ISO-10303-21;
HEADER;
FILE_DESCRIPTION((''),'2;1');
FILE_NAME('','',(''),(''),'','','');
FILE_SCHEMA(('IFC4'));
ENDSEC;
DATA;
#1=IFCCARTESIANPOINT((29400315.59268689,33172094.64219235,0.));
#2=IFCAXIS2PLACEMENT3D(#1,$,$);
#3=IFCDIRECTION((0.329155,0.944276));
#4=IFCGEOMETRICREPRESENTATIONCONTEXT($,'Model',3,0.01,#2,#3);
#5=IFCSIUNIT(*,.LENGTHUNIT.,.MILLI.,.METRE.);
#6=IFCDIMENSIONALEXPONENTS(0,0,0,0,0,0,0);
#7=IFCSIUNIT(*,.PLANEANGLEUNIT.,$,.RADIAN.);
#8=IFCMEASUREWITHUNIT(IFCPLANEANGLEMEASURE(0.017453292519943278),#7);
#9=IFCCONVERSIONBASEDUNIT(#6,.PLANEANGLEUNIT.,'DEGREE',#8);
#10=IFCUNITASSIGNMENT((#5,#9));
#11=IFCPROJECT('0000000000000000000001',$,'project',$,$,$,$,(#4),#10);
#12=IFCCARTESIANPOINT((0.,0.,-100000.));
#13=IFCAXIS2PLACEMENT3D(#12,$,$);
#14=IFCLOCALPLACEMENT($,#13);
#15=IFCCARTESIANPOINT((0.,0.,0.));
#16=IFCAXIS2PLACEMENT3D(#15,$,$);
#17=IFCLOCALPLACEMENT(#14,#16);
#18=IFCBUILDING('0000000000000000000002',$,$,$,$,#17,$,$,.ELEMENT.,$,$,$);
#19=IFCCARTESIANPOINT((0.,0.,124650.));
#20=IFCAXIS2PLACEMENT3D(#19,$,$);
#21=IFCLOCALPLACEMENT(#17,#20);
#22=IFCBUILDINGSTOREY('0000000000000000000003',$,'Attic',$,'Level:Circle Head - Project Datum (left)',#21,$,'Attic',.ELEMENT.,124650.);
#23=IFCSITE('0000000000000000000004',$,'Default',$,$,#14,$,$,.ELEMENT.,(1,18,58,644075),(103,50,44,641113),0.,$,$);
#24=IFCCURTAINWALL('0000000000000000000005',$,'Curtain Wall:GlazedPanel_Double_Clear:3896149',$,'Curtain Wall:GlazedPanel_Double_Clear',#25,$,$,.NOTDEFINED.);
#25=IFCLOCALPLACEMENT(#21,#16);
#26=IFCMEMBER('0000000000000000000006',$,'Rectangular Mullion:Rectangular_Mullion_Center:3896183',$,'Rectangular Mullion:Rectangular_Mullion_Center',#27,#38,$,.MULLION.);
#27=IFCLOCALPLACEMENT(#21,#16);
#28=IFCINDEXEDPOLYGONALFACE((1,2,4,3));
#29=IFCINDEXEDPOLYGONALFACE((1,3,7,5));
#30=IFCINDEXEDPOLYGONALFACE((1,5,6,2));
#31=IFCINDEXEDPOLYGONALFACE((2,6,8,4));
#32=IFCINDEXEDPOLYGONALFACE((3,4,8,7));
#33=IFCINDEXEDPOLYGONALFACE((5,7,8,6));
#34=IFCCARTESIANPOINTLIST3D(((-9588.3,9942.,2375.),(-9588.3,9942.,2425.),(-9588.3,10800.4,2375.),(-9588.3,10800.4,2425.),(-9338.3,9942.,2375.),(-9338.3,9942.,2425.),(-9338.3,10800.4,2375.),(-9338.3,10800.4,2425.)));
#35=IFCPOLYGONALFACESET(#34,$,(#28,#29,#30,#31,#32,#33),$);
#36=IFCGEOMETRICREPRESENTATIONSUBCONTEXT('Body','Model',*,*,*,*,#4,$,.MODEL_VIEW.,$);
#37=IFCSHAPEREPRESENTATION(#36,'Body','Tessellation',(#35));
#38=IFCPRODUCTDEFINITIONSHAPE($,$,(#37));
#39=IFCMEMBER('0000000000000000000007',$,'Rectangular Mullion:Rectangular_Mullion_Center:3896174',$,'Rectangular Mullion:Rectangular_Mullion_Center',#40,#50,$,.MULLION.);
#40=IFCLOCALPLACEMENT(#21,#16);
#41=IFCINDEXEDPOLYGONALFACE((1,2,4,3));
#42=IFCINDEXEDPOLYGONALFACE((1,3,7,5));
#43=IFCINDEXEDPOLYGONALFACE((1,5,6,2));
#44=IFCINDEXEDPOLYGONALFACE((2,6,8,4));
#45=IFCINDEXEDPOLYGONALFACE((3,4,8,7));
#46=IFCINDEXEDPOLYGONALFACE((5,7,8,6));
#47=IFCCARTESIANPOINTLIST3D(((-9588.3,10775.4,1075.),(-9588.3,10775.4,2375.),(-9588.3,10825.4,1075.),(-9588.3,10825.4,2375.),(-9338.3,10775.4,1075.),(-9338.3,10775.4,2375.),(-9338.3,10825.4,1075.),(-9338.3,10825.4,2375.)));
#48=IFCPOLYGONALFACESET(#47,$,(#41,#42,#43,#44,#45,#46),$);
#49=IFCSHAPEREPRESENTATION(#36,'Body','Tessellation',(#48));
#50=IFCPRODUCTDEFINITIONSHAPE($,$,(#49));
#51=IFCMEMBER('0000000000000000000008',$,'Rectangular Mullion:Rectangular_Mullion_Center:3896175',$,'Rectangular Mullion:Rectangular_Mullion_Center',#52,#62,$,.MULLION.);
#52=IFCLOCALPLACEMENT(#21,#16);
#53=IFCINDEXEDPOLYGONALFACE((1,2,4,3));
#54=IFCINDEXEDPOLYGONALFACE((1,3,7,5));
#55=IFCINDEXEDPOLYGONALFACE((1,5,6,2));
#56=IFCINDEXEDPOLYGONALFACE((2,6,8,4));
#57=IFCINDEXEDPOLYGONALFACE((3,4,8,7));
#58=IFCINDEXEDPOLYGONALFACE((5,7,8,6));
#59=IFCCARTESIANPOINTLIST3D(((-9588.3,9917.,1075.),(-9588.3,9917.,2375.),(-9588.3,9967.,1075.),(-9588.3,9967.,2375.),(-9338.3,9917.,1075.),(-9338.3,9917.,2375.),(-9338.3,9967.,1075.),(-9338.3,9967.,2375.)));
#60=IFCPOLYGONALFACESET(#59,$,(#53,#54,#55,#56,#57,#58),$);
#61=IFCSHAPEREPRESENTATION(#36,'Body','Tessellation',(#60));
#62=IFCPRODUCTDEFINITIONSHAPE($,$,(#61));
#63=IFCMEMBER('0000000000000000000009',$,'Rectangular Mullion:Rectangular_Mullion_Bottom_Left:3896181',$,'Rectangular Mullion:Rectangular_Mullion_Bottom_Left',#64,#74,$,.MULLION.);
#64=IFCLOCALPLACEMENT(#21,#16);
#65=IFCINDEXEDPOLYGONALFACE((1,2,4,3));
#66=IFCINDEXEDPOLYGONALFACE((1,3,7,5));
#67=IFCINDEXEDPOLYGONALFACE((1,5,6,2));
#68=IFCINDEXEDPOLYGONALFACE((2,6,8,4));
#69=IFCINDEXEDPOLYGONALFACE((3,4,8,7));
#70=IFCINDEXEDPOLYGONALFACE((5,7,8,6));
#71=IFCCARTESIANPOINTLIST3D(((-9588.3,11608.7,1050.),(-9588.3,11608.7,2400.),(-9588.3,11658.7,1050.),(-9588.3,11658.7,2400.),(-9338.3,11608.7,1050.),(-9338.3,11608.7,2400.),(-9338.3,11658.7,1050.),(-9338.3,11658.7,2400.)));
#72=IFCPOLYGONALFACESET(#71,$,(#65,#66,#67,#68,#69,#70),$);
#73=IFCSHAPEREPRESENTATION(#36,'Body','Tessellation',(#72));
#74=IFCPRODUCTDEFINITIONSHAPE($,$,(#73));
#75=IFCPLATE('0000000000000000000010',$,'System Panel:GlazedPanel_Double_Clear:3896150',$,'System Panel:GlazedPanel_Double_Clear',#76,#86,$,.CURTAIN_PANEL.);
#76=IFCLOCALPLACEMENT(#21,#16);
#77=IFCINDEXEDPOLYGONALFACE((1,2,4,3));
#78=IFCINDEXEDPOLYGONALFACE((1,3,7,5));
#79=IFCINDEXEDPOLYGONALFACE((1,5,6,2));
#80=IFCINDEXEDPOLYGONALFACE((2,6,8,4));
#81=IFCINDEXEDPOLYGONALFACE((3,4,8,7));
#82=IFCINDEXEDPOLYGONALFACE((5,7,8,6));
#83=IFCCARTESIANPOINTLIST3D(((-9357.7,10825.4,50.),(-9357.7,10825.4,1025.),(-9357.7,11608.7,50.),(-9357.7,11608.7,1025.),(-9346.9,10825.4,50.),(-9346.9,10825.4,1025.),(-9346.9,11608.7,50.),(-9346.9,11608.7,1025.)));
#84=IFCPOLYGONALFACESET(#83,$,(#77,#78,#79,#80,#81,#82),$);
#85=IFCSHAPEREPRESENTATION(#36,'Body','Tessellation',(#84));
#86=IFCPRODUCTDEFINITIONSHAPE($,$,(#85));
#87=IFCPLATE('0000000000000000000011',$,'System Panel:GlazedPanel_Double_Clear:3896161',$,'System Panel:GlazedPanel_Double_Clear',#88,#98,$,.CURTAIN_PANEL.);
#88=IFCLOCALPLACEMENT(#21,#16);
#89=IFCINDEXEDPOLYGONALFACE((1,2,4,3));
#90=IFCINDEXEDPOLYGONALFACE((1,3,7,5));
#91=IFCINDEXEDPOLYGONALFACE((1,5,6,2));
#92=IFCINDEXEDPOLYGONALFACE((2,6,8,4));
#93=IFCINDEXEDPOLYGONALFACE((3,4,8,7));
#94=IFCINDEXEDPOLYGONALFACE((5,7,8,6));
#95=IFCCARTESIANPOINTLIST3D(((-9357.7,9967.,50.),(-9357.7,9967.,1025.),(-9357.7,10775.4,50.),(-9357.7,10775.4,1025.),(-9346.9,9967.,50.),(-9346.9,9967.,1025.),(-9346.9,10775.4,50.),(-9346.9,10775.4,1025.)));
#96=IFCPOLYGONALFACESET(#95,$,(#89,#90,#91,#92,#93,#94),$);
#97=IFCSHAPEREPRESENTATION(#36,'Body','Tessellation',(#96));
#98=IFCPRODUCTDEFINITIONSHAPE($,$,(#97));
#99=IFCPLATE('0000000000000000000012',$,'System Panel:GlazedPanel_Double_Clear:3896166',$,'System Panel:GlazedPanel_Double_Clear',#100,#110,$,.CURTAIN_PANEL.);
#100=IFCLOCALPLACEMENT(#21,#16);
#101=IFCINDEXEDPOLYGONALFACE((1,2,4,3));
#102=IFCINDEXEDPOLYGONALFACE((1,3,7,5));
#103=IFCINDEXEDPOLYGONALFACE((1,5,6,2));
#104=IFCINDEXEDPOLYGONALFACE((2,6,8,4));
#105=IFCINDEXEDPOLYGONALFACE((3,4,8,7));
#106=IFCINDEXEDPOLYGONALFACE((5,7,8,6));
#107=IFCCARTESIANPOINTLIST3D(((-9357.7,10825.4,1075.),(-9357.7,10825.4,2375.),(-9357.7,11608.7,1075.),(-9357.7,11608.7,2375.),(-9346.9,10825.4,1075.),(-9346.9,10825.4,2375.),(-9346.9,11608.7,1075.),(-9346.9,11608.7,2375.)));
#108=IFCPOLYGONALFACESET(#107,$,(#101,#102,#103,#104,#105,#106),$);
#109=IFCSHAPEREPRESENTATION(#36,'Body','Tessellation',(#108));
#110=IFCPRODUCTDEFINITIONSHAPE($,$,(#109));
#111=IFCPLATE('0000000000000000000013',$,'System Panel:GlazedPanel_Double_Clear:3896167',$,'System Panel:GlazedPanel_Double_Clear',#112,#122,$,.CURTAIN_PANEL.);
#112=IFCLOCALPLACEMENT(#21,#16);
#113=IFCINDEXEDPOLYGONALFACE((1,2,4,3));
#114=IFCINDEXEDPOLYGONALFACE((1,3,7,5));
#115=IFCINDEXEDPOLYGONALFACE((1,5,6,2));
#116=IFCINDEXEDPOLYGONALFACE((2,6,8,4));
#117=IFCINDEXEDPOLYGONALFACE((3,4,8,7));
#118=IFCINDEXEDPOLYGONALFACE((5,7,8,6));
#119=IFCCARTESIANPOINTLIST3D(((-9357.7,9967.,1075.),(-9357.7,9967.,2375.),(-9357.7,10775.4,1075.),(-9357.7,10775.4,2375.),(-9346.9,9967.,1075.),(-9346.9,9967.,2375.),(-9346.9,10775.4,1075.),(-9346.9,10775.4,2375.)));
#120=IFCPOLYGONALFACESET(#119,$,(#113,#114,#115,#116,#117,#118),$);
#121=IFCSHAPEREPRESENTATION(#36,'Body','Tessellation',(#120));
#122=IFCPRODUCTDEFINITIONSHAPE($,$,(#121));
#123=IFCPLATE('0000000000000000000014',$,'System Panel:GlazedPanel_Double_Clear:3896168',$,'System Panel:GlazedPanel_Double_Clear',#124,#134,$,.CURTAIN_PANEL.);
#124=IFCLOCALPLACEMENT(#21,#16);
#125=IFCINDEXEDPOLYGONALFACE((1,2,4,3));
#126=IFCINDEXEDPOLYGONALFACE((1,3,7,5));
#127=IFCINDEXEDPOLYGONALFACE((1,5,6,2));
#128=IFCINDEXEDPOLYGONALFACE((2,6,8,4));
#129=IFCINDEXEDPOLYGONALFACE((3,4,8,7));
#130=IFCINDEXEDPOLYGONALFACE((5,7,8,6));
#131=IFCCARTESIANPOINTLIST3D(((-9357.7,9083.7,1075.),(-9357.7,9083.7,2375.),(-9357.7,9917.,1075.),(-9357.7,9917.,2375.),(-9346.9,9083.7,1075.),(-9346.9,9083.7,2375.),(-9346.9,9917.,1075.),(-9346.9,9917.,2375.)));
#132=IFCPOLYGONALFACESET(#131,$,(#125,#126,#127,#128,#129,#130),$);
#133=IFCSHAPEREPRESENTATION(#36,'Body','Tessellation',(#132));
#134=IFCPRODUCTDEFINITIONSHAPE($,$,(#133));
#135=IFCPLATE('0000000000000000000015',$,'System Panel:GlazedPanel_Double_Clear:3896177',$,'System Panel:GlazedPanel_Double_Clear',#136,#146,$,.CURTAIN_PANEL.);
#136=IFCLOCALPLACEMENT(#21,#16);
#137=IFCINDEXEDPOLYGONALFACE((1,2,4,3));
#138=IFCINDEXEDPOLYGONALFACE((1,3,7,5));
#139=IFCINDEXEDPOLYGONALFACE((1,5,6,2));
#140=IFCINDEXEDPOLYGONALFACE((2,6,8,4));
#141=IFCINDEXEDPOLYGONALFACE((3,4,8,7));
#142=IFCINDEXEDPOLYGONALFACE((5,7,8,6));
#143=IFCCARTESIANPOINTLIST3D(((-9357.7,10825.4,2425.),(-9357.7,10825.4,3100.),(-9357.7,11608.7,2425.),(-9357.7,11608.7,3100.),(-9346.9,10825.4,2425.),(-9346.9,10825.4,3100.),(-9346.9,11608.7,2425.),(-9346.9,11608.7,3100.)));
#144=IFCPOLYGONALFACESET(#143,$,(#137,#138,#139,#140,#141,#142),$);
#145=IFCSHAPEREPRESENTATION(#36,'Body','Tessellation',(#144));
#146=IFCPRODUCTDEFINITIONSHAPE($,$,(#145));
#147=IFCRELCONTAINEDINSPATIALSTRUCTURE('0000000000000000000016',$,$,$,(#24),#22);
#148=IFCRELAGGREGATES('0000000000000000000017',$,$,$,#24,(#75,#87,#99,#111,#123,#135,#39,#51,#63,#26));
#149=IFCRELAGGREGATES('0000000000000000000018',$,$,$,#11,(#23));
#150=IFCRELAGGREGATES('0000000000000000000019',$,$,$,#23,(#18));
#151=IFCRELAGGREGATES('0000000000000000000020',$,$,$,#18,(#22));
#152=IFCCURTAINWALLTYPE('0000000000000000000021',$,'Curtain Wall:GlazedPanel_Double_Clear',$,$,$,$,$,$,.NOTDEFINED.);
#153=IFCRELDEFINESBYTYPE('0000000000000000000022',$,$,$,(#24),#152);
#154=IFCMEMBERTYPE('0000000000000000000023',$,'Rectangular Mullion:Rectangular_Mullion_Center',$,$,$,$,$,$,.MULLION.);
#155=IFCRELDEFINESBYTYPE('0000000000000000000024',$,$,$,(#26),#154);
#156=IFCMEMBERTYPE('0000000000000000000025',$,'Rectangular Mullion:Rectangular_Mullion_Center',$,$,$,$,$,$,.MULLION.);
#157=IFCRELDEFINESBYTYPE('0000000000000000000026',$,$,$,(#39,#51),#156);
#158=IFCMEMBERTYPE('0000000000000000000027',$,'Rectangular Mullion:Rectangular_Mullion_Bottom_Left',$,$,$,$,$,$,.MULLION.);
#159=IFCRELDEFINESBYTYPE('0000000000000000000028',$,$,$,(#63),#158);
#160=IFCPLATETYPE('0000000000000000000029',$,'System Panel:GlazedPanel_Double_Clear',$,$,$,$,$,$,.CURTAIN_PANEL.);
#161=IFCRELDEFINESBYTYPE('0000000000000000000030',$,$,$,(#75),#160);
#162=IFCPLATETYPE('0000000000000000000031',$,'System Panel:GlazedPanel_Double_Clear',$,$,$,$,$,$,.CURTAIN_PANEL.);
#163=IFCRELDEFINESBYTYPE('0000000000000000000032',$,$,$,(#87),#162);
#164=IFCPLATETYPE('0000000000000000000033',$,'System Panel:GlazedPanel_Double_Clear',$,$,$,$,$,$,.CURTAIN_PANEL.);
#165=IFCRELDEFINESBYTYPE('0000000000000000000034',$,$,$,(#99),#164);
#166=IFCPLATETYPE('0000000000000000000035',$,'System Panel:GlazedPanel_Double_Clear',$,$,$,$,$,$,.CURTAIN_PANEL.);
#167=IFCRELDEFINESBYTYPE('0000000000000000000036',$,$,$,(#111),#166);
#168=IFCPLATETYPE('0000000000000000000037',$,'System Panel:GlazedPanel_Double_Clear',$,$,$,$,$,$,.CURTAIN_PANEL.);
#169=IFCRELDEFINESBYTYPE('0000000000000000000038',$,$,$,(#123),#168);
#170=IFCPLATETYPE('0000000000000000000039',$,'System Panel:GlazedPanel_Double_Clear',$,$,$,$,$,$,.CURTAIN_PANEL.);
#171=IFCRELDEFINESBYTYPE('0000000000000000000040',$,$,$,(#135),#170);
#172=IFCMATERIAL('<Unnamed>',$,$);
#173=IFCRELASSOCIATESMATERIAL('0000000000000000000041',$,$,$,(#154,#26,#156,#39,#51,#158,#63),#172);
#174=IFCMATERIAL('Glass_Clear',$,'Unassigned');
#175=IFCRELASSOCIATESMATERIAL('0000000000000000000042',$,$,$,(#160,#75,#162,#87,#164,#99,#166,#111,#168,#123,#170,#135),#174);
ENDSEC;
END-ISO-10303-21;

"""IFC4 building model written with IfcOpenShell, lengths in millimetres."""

from ifc_helpers import new_model, entity, si_unit, converted_unit, direction, frame, origin, place, context, subcontext, project, spatial, indexed_curve, outline, extrude, source, transform, mapped, material, type_object, type_shapes, element, aggregate, save


model = new_model("IFC4")

# Units and contexts
model_context = context("Model", 3, precision=0.01, world=frame((29400315.59268689, 33172094.64219235, 0.0)), true_north=direction((0.329155, 0.944276)))
body_context = subcontext(model_context, "Body", "Model", "MODEL_VIEW")
ifc_project = project(units=[si_unit("LENGTHUNIT", "METRE", prefix="MILLI"), converted_unit("PLANEANGLEUNIT", "DEGREE", entity("IfcPlaneAngleMeasure", 0.017453292519943278), si_unit("PLANEANGLEUNIT", "RADIAN"), dimensions=[0, 0, 0, 0, 0, 0, 0])], contexts=[model_context])

# Site, building, storey
site_placement = place(None, frame((0.0, 0.0, -100000.0)))
site = spatial("IfcSite", under=ifc_project, at=site_placement, Name="Default", CompositionType="ELEMENT", RefLatitude=(1, 18, 58, 644075), RefLongitude=(103, 50, 44, 641113), RefElevation=0.0)
building_placement = place(site_placement, origin())
building = spatial("IfcBuilding", under=site, at=building_placement, CompositionType="ELEMENT")
storey_placement = place(building_placement, frame((0.0, 0.0, 124650.0)))
storey = spatial("IfcBuildingStorey", under=building, at=storey_placement, Name="Attic", ObjectType="Level:Circle Head - Project Datum (left)", LongName="Attic", CompositionType="ELEMENT", Elevation=124650.0)

# Curtain wall, members, plates
curtain_wall_type = type_object("IfcCurtainWallType", Name="Curtain Wall:GlazedPanel_Double_Clear", PredefinedType="NOTDEFINED")
curtain_wall_placement = place(storey_placement, frame((0.0, 0.0, -124650.0)))
curtain_wall = element("IfcCurtainWall", 1, at=curtain_wall_placement, inside=storey, type_object=curtain_wall_type, Name="Curtain Wall:GlazedPanel_Double_Clear:3896149", ObjectType="Curtain Wall:GlazedPanel_Double_Clear", PredefinedType="NOTDEFINED")
ifc_material_1 = material(Name="<Unnamed>")
member_type_1 = type_object("IfcMemberType", Name="Rectangular Mullion:Rectangular_Mullion_Center", PredefinedType="MULLION", material=ifc_material_1)
shared_shape_1 = source(origin(), body_context, "Body", "SweptSolid", [
    extrude(outline(indexed_curve([(-25.0, -125.0), (25.0, -125.0), (25.0, 125.0), (-25.0, 125.0), (-25.0, -125.0)], self_intersect=False)), frame((0.0, 0.0, -858.3), z_axis=(0.0, 0.0, 1.0), x_axis=(-1.0, 0.0, 0.0)), (0.0, 0.0, 1.0), 858.3),
])
type_shapes(member_type_1, [shared_shape_1])
member_1_placement = place(curtain_wall_placement, frame((-9463.3, 9942.0, 127050.0), z_axis=(0.0, -1.0, 0.0), x_axis=(0.0, 0.0, 1.0)))
member_1 = element("IfcMember", 2, at=member_1_placement, type_object=member_type_1, material=ifc_material_1, Name="Rectangular Mullion:Rectangular_Mullion_Center:3896183", ObjectType="Rectangular Mullion:Rectangular_Mullion_Center", PredefinedType="MULLION", context=body_context, shape_type="MappedRepresentation", body=[
    mapped(shared_shape_1, transform((0.0, 0.0, 0.0), scale=1.0)),
])
member_type_2 = type_object("IfcMemberType", Name="Rectangular Mullion:Rectangular_Mullion_Center", PredefinedType="MULLION", material=ifc_material_1)
shared_shape_2 = source(origin(), body_context, "Body", "SweptSolid", [
    extrude(outline(indexed_curve([(-25.0, -125.0), (25.0, -125.0), (25.0, 125.0), (-25.0, 125.0), (-25.0, -125.0)], self_intersect=False)), frame((0.0, 0.0, -1300.0), z_axis=(0.0, 0.0, 1.0), x_axis=(-1.0, 0.0, 0.0)), (0.0, 0.0, 1.0), 1300.0),
])
type_shapes(member_type_2, [shared_shape_2])
member_2_placement = place(curtain_wall_placement, frame((-9463.3, 10800.4, 125725.0), z_axis=(0.0, 0.0, -1.0), x_axis=(0.0, -1.0, 0.0)))
member_2 = element("IfcMember", 3, at=member_2_placement, type_object=member_type_2, material=ifc_material_1, Name="Rectangular Mullion:Rectangular_Mullion_Center:3896174", ObjectType="Rectangular Mullion:Rectangular_Mullion_Center", PredefinedType="MULLION", context=body_context, shape_type="MappedRepresentation", body=[
    mapped(shared_shape_2, transform((0.0, 0.0, 0.0), scale=1.0)),
])
member_3_placement = place(curtain_wall_placement, frame((-9463.3, 9942.0, 125725.0), z_axis=(0.0, 0.0, -1.0), x_axis=(0.0, -1.0, 0.0)))
member_3 = element("IfcMember", 4, at=member_3_placement, type_object=member_type_2, material=ifc_material_1, Name="Rectangular Mullion:Rectangular_Mullion_Center:3896175", ObjectType="Rectangular Mullion:Rectangular_Mullion_Center", PredefinedType="MULLION", context=body_context, shape_type="MappedRepresentation", body=[
    mapped(shared_shape_2, transform((0.0, 0.0, 0.0), scale=1.0)),
])
member_type_3 = type_object("IfcMemberType", Name="Rectangular Mullion:Rectangular_Mullion_Bottom_Left", PredefinedType="MULLION", material=ifc_material_1)
shared_shape_3 = source(origin(), body_context, "Body", "SweptSolid", [
    extrude(outline(indexed_curve([(-25.0, -125.0), (25.0, -125.0), (25.0, 125.0), (-25.0, 125.0), (-25.0, -125.0)], self_intersect=False)), frame((-25.0, 0.0, -1350.0), z_axis=(0.0, 0.0, 1.0), x_axis=(-1.0, 0.0, 0.0)), (0.0, 0.0, 1.0), 1350.0),
])
type_shapes(member_type_3, [shared_shape_3])
member_4_placement = place(curtain_wall_placement, frame((-9463.3, 11658.7, 127050.0), z_axis=(0.0, 0.0, 1.0), x_axis=(0.0, 1.0, 0.0)))
member_4 = element("IfcMember", 5, at=member_4_placement, type_object=member_type_3, material=ifc_material_1, Name="Rectangular Mullion:Rectangular_Mullion_Bottom_Left:3896181", ObjectType="Rectangular Mullion:Rectangular_Mullion_Bottom_Left", PredefinedType="MULLION", context=body_context, shape_type="MappedRepresentation", body=[
    mapped(shared_shape_3, transform((0.0, 0.0, 0.0), scale=1.0)),
])
ifc_material_2 = material(Name="Glass_Clear", Category="Unassigned")
plate_type_1 = type_object("IfcPlateType", Name="System Panel:GlazedPanel_Double_Clear", PredefinedType="CURTAIN_PANEL", material=ifc_material_2)
shared_shape_4 = source(origin(), body_context, "Body", "SweptSolid", [
    extrude(outline(indexed_curve([(-5.4, -391.7), (5.4, -391.7), (5.4, 391.7), (-5.4, 391.7), (-5.4, -391.7)], self_intersect=False)), frame((0.0, 111.0, 0.0), z_axis=(0.0, 0.0, 1.0), x_axis=(0.0, 1.0, 0.0)), (0.0, 0.0, 1.0), 975.0),
])
type_shapes(plate_type_1, [shared_shape_4])
plate_1_placement = place(curtain_wall_placement, frame((-9463.3, 11217.0, 124700.0), z_axis=(0.0, 0.0, 1.0), x_axis=(0.0, -1.0, 0.0)))
plate_1 = element("IfcPlate", 6, at=plate_1_placement, type_object=plate_type_1, material=ifc_material_2, Name="System Panel:GlazedPanel_Double_Clear:3896150", ObjectType="System Panel:GlazedPanel_Double_Clear", PredefinedType="CURTAIN_PANEL", context=body_context, shape_type="MappedRepresentation", body=[
    mapped(shared_shape_4, transform((0.0, 0.0, 0.0), scale=1.0)),
])
plate_type_2 = type_object("IfcPlateType", Name="System Panel:GlazedPanel_Double_Clear", PredefinedType="CURTAIN_PANEL", material=ifc_material_2)
shared_shape_5 = source(origin(), body_context, "Body", "SweptSolid", [
    extrude(outline(indexed_curve([(-5.4, -404.2), (5.4, -404.2), (5.4, 404.2), (-5.4, 404.2), (-5.4, -404.2)], self_intersect=False)), frame((0.0, 111.0, 0.0), z_axis=(0.0, 0.0, 1.0), x_axis=(0.0, 1.0, 0.0)), (0.0, 0.0, 1.0), 975.0),
])
type_shapes(plate_type_2, [shared_shape_5])
plate_2_placement = place(curtain_wall_placement, frame((-9463.3, 10371.2, 124700.0), z_axis=(0.0, 0.0, 1.0), x_axis=(0.0, -1.0, 0.0)))
plate_2 = element("IfcPlate", 7, at=plate_2_placement, type_object=plate_type_2, material=ifc_material_2, Name="System Panel:GlazedPanel_Double_Clear:3896161", ObjectType="System Panel:GlazedPanel_Double_Clear", PredefinedType="CURTAIN_PANEL", context=body_context, shape_type="MappedRepresentation", body=[
    mapped(shared_shape_5, transform((0.0, 0.0, 0.0), scale=1.0)),
])
plate_type_3 = type_object("IfcPlateType", Name="System Panel:GlazedPanel_Double_Clear", PredefinedType="CURTAIN_PANEL", material=ifc_material_2)
shared_shape_6 = source(origin(), body_context, "Body", "SweptSolid", [
    extrude(outline(indexed_curve([(-5.4, -391.7), (5.4, -391.7), (5.4, 391.7), (-5.4, 391.7), (-5.4, -391.7)], self_intersect=False)), frame((0.0, 111.0, 0.0), z_axis=(0.0, 0.0, 1.0), x_axis=(0.0, 1.0, 0.0)), (0.0, 0.0, 1.0), 1300.0),
])
type_shapes(plate_type_3, [shared_shape_6])
plate_3_placement = place(curtain_wall_placement, frame((-9463.3, 11217.0, 125725.0), z_axis=(0.0, 0.0, 1.0), x_axis=(0.0, -1.0, 0.0)))
plate_3 = element("IfcPlate", 8, at=plate_3_placement, type_object=plate_type_3, material=ifc_material_2, Name="System Panel:GlazedPanel_Double_Clear:3896166", ObjectType="System Panel:GlazedPanel_Double_Clear", PredefinedType="CURTAIN_PANEL", context=body_context, shape_type="MappedRepresentation", body=[
    mapped(shared_shape_6, transform((0.0, 0.0, 0.0), scale=1.0)),
])
plate_type_4 = type_object("IfcPlateType", Name="System Panel:GlazedPanel_Double_Clear", PredefinedType="CURTAIN_PANEL", material=ifc_material_2)
shared_shape_7 = source(origin(), body_context, "Body", "SweptSolid", [
    extrude(outline(indexed_curve([(-5.4, -404.2), (5.4, -404.2), (5.4, 404.2), (-5.4, 404.2), (-5.4, -404.2)], self_intersect=False)), frame((0.0, 111.0, 0.0), z_axis=(0.0, 0.0, 1.0), x_axis=(0.0, 1.0, 0.0)), (0.0, 0.0, 1.0), 1300.0),
])
type_shapes(plate_type_4, [shared_shape_7])
plate_4_placement = place(curtain_wall_placement, frame((-9463.3, 10371.2, 125725.0), z_axis=(0.0, 0.0, 1.0), x_axis=(0.0, -1.0, 0.0)))
plate_4 = element("IfcPlate", 9, at=plate_4_placement, type_object=plate_type_4, material=ifc_material_2, Name="System Panel:GlazedPanel_Double_Clear:3896167", ObjectType="System Panel:GlazedPanel_Double_Clear", PredefinedType="CURTAIN_PANEL", context=body_context, shape_type="MappedRepresentation", body=[
    mapped(shared_shape_7, transform((0.0, 0.0, 0.0), scale=1.0)),
])
plate_type_5 = type_object("IfcPlateType", Name="System Panel:GlazedPanel_Double_Clear", PredefinedType="CURTAIN_PANEL", material=ifc_material_2)
shared_shape_8 = source(origin(), body_context, "Body", "SweptSolid", [
    extrude(outline(indexed_curve([(-5.4, -416.7), (5.4, -416.7), (5.4, 416.7), (-5.4, 416.7), (-5.4, -416.7)], self_intersect=False)), frame((0.0, 111.0, 0.0), z_axis=(0.0, 0.0, 1.0), x_axis=(0.0, 1.0, 0.0)), (0.0, 0.0, 1.0), 1300.0),
])
type_shapes(plate_type_5, [shared_shape_8])
plate_5_placement = place(curtain_wall_placement, frame((-9463.3, 9500.4, 125725.0), z_axis=(0.0, 0.0, 1.0), x_axis=(0.0, -1.0, 0.0)))
plate_5 = element("IfcPlate", 10, at=plate_5_placement, type_object=plate_type_5, material=ifc_material_2, Name="System Panel:GlazedPanel_Double_Clear:3896168", ObjectType="System Panel:GlazedPanel_Double_Clear", PredefinedType="CURTAIN_PANEL", context=body_context, shape_type="MappedRepresentation", body=[
    mapped(shared_shape_8, transform((0.0, 0.0, 0.0), scale=1.0)),
])
plate_type_6 = type_object("IfcPlateType", Name="System Panel:GlazedPanel_Double_Clear", PredefinedType="CURTAIN_PANEL", material=ifc_material_2)
shared_shape_9 = source(origin(), body_context, "Body", "SweptSolid", [
    extrude(outline(indexed_curve([(-5.4, -391.7), (5.4, -391.7), (5.4, 391.7), (-5.4, 391.7), (-5.4, -391.7)], self_intersect=False)), frame((0.0, 111.0, 0.0), z_axis=(0.0, 0.0, 1.0), x_axis=(0.0, 1.0, 0.0)), (0.0, 0.0, 1.0), 675.0),
])
type_shapes(plate_type_6, [shared_shape_9])
plate_6_placement = place(curtain_wall_placement, frame((-9463.3, 11217.0, 127075.0), z_axis=(0.0, 0.0, 1.0), x_axis=(0.0, -1.0, 0.0)))
plate_6 = element("IfcPlate", 11, at=plate_6_placement, type_object=plate_type_6, material=ifc_material_2, Name="System Panel:GlazedPanel_Double_Clear:3896177", ObjectType="System Panel:GlazedPanel_Double_Clear", PredefinedType="CURTAIN_PANEL", context=body_context, shape_type="MappedRepresentation", body=[
    mapped(shared_shape_9, transform((0.0, 0.0, 0.0), scale=1.0)),
])
aggregate(curtain_wall, [plate_1, plate_2, plate_3, plate_4, plate_5, plate_6, member_2, member_3, member_4, member_1])

save(model, "model.ifc")
